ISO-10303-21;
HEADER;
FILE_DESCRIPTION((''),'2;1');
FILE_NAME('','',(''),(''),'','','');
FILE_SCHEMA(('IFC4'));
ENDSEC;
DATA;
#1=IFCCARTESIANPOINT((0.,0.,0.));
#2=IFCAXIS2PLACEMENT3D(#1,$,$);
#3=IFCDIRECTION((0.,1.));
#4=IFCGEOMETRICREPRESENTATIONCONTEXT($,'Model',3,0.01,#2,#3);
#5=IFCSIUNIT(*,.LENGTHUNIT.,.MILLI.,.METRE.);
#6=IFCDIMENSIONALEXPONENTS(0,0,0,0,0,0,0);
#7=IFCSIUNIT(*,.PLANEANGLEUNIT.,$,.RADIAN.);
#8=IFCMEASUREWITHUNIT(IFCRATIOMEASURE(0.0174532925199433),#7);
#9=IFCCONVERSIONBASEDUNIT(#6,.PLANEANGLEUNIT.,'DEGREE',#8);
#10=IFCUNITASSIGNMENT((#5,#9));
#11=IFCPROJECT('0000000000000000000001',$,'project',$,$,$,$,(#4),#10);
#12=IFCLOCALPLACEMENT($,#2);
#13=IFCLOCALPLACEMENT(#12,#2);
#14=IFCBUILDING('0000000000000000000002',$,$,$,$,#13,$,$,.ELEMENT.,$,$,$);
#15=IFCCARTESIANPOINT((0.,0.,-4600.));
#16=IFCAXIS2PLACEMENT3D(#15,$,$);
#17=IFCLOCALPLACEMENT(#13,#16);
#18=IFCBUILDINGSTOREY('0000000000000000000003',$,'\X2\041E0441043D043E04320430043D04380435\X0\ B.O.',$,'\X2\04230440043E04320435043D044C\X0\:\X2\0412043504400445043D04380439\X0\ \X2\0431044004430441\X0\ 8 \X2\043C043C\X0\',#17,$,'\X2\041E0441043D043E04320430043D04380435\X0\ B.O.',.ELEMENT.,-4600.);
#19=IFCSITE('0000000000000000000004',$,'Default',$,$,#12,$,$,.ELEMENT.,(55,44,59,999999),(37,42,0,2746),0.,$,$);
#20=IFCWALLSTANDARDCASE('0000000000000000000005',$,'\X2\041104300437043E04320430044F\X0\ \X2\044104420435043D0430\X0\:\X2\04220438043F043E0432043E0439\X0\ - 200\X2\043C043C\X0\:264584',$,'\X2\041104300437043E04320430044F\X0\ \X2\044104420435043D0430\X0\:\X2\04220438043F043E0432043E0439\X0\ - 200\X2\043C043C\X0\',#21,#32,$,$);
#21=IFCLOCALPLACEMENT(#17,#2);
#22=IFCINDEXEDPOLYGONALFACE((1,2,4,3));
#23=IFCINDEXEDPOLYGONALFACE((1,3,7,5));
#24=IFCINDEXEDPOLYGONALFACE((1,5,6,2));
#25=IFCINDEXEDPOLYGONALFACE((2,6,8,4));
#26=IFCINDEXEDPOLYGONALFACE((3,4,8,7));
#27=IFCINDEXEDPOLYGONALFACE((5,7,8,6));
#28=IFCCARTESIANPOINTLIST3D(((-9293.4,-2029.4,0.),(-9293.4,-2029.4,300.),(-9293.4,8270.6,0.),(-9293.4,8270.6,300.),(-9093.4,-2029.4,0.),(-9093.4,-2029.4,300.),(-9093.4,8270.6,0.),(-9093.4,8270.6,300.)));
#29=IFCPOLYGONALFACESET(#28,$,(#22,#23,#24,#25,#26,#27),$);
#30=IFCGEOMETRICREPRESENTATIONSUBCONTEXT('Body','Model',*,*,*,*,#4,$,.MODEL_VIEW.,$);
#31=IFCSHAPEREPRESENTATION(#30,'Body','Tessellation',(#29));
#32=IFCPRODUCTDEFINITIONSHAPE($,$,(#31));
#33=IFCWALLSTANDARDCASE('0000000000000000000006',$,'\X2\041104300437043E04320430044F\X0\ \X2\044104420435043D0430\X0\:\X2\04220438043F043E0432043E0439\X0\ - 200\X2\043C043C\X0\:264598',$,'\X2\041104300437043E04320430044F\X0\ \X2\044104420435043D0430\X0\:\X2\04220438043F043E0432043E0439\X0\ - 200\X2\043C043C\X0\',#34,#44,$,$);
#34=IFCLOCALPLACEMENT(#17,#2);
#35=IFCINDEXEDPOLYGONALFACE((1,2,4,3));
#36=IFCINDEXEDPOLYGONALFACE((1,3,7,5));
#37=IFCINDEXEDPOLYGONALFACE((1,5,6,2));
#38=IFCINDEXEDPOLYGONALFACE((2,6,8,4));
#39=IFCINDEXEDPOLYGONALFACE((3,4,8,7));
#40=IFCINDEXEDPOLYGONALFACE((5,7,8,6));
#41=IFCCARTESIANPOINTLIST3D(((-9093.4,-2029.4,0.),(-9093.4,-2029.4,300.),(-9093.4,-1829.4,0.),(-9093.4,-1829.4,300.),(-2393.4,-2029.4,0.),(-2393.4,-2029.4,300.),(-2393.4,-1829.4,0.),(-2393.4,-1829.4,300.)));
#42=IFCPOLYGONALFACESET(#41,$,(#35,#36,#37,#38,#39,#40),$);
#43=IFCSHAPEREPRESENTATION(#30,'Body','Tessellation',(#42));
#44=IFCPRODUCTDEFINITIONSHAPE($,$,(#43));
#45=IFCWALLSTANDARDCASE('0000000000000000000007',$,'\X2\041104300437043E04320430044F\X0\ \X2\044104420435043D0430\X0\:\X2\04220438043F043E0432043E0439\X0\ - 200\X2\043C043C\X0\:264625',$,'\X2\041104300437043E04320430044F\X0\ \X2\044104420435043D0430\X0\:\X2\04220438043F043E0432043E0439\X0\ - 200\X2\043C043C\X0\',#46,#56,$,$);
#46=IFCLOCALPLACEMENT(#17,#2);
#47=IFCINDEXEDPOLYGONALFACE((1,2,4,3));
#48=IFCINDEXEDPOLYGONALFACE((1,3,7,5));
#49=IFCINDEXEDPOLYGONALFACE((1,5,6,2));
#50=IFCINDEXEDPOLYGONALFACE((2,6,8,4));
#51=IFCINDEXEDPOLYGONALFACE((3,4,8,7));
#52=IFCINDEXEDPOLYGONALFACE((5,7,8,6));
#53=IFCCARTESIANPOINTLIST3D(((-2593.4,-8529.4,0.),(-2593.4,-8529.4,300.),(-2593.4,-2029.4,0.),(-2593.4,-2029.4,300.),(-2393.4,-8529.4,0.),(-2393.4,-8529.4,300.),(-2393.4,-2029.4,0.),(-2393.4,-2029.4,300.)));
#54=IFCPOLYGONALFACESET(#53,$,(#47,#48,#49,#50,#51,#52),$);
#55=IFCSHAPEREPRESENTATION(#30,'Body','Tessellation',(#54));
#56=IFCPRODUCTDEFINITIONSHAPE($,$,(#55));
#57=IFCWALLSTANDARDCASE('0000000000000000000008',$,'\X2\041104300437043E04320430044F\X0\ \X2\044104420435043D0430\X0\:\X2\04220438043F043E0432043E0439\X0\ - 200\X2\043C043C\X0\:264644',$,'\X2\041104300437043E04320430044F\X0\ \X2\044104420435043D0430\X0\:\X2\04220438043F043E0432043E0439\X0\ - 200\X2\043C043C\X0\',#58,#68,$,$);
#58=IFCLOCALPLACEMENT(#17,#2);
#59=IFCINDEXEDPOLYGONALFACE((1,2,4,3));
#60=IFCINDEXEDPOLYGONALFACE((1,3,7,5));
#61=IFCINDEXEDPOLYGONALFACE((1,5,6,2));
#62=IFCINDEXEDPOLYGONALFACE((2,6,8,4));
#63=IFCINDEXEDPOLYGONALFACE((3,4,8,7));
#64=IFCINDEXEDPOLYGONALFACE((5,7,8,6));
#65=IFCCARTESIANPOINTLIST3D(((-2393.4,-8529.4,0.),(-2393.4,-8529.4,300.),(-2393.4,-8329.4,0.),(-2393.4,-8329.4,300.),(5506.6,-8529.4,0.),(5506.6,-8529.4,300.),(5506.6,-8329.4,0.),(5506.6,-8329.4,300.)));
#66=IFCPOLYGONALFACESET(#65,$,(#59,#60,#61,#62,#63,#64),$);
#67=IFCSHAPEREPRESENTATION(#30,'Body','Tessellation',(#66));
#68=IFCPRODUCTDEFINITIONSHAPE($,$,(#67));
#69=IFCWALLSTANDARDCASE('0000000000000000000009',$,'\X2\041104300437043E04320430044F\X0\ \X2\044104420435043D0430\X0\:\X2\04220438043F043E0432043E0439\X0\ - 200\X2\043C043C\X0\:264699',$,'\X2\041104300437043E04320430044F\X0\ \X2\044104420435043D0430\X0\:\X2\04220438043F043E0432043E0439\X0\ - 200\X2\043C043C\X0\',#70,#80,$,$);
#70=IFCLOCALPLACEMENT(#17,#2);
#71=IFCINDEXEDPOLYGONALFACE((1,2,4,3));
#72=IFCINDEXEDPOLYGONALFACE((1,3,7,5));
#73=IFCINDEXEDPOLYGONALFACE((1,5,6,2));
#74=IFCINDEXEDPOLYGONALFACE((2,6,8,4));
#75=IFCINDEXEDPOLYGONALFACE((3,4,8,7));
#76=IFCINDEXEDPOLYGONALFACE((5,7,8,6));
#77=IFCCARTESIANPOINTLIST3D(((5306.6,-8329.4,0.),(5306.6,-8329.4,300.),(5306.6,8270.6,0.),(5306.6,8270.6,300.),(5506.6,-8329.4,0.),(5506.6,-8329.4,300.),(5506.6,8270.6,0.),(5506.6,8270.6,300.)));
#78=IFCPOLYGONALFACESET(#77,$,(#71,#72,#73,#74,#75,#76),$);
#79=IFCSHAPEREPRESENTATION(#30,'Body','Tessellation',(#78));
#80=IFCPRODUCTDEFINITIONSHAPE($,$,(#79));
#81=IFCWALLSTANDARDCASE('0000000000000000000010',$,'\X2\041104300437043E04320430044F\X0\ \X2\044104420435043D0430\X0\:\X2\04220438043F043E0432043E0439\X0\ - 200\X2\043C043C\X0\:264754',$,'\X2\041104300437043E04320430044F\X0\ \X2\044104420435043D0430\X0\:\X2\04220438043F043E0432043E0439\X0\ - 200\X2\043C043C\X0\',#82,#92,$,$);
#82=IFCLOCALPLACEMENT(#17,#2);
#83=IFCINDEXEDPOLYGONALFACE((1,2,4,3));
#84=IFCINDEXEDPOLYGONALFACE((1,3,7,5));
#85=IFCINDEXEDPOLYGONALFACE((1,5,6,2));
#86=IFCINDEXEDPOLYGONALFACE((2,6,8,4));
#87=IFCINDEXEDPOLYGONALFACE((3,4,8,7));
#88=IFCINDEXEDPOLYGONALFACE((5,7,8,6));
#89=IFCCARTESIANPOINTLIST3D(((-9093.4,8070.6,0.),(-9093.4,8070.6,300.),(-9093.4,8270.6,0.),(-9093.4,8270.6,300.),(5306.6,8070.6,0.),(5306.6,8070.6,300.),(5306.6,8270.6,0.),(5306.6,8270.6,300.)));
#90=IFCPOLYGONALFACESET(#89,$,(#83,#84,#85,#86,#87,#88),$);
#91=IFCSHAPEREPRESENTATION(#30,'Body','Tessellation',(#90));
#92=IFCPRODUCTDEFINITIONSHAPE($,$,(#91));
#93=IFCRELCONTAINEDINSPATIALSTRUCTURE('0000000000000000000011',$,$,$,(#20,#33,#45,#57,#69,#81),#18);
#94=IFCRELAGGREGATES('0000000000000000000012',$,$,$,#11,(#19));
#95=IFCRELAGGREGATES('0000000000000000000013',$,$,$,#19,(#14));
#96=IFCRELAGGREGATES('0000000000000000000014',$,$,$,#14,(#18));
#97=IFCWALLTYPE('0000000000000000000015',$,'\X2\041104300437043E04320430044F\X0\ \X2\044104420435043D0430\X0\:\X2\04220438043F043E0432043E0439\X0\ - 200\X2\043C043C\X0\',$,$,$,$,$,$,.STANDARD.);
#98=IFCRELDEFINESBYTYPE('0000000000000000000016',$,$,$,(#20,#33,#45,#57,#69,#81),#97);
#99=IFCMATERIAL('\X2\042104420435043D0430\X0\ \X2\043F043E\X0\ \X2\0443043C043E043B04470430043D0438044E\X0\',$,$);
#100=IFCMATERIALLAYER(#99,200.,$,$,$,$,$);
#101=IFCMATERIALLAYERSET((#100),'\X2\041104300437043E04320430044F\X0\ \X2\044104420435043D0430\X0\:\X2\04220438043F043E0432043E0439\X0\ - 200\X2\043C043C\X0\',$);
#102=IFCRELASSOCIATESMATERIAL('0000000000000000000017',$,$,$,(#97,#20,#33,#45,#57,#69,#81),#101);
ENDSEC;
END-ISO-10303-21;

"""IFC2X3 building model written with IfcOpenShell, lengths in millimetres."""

from ifc_helpers import new_model, entity, si_unit, converted_unit, direction, frame, frame_2d, origin, place, context, subcontext, project, spatial, rectangle, extrude, clip, halfspace, material, layer, layer_set, layer_usage, type_object, element, save


model = new_model("IFC2X3")

# Units and contexts
model_context = context("Model", 3, precision=0.01, world=origin(), true_north=direction((0.0, 1.0)))
body_context = subcontext(model_context, "Body", "Model", "MODEL_VIEW")
ifc_project = project(units=[si_unit("LENGTHUNIT", "METRE", prefix="MILLI"), converted_unit("PLANEANGLEUNIT", "DEGREE", entity("IfcRatioMeasure", 0.0174532925199433), si_unit("PLANEANGLEUNIT", "RADIAN"), dimensions=[0, 0, 0, 0, 0, 0, 0])], contexts=[model_context])

# Site, building, storey
site_placement = place(None, origin())
site = spatial("IfcSite", under=ifc_project, at=site_placement, Name="Default", CompositionType="ELEMENT", RefLatitude=(55, 44, 59, 999999), RefLongitude=(37, 42, 0, 2746), RefElevation=0.0)
building_placement = place(site_placement, origin())
building = spatial("IfcBuilding", under=site, at=building_placement, CompositionType="ELEMENT")
storey_placement = place(building_placement, frame((0.0, 0.0, -4600.0)))
storey = spatial("IfcBuildingStorey", under=building, at=storey_placement, Name="Основание B.O.", ObjectType="Уровень:Верхний брус 8 мм", LongName="Основание B.O.", CompositionType="ELEMENT", Elevation=-4600.0)

# Walls
ifc_material = material(Name="Стена по умолчанию")
ifc_layer = layer(ifc_material, 200.0)
ifc_layer_set = layer_set([ifc_layer], Name="Базовая стена:Типовой - 200мм")
ifc_layer_usage_1 = layer_usage(ifc_layer_set, "AXIS2", "NEGATIVE", 100.0)
wall_type = type_object("IfcWallType", Name="Базовая стена:Типовой - 200мм", PredefinedType="STANDARD", material=ifc_layer_set)
wall_1_placement = place(storey_placement, frame((-9193.4, 8270.6, 0.0), z_axis=(0.0, 0.0, 1.0), x_axis=(0.0, -1.0, 0.0)))
element("IfcWallStandardCase", 1, at=wall_1_placement, inside=storey, type_object=wall_type, material=ifc_layer_usage_1, Name="Базовая стена:Типовой - 200мм:264584", ObjectType="Базовая стена:Типовой - 200мм", context=body_context, shape_type="Clipping", body=[
    clip(extrude(rectangle(XDim=10300.0, YDim=200.0, at=frame_2d((5150.0, 0.0), x_axis=(-1.0, 0.0))), origin(), (0.0, 0.0, 1.0), 300.0), halfspace(origin(), True)),
])
ifc_layer_usage_2 = layer_usage(ifc_layer_set, "AXIS2", "NEGATIVE", 100.0)
wall_2_placement = place(storey_placement, frame((-9093.4, -1929.4, 0.0)))
element("IfcWallStandardCase", 2, at=wall_2_placement, inside=storey, type_object=wall_type, material=ifc_layer_usage_2, Name="Базовая стена:Типовой - 200мм:264598", ObjectType="Базовая стена:Типовой - 200мм", context=body_context, shape_type="Clipping", body=[
    clip(extrude(rectangle(XDim=6700.0, YDim=200.0, at=frame_2d((3350.0, 0.0), x_axis=(-1.0, 0.0))), origin(), (0.0, 0.0, 1.0), 300.0), halfspace(origin(), True)),
])
ifc_layer_usage_3 = layer_usage(ifc_layer_set, "AXIS2", "NEGATIVE", 100.0)
wall_3_placement = place(storey_placement, frame((-2493.4, -2029.4, 0.0), z_axis=(0.0, 0.0, 1.0), x_axis=(0.0, -1.0, 0.0)))
element("IfcWallStandardCase", 3, at=wall_3_placement, inside=storey, type_object=wall_type, material=ifc_layer_usage_3, Name="Базовая стена:Типовой - 200мм:264625", ObjectType="Базовая стена:Типовой - 200мм", context=body_context, shape_type="Clipping", body=[
    clip(extrude(rectangle(XDim=6500.0, YDim=200.0, at=frame_2d((3250.0, 0.0), x_axis=(-1.0, 0.0))), origin(), (0.0, 0.0, 1.0), 300.0), halfspace(origin(), True)),
])
ifc_layer_usage_4 = layer_usage(ifc_layer_set, "AXIS2", "NEGATIVE", 100.0)
wall_4_placement = place(storey_placement, frame((-2393.4, -8429.4, 0.0)))
element("IfcWallStandardCase", 4, at=wall_4_placement, inside=storey, type_object=wall_type, material=ifc_layer_usage_4, Name="Базовая стена:Типовой - 200мм:264644", ObjectType="Базовая стена:Типовой - 200мм", context=body_context, shape_type="Clipping", body=[
    clip(extrude(rectangle(XDim=7900.0, YDim=200.0, at=frame_2d((3950.0, 0.0), x_axis=(-1.0, 0.0))), origin(), (0.0, 0.0, 1.0), 300.0), halfspace(origin(), True)),
])
ifc_layer_usage_5 = layer_usage(ifc_layer_set, "AXIS2", "NEGATIVE", 100.0)
wall_5_placement = place(storey_placement, frame((5406.6, -8329.4, 0.0), z_axis=(0.0, 0.0, 1.0), x_axis=(0.0, 1.0, 0.0)))
element("IfcWallStandardCase", 5, at=wall_5_placement, inside=storey, type_object=wall_type, material=ifc_layer_usage_5, Name="Базовая стена:Типовой - 200мм:264699", ObjectType="Базовая стена:Типовой - 200мм", context=body_context, shape_type="Clipping", body=[
    clip(extrude(rectangle(XDim=16600.0, YDim=200.0, at=frame_2d((8300.0, 0.0), x_axis=(-1.0, 0.0))), origin(), (0.0, 0.0, 1.0), 300.0), halfspace(origin(), True)),
])
ifc_layer_usage_6 = layer_usage(ifc_layer_set, "AXIS2", "NEGATIVE", 100.0)
wall_6_placement = place(storey_placement, frame((5306.6, 8170.6, 0.0), z_axis=(0.0, 0.0, 1.0), x_axis=(-1.0, 0.0, 0.0)))
element("IfcWallStandardCase", 6, at=wall_6_placement, inside=storey, type_object=wall_type, material=ifc_layer_usage_6, Name="Базовая стена:Типовой - 200мм:264754", ObjectType="Базовая стена:Типовой - 200мм", context=body_context, shape_type="Clipping", body=[
    clip(extrude(rectangle(XDim=14400.0, YDim=200.0, at=frame_2d((7200.0, 0.0), x_axis=(-1.0, 0.0))), origin(), (0.0, 0.0, 1.0), 300.0), halfspace(origin(), True)),
])

save(model, "model.ifc")
